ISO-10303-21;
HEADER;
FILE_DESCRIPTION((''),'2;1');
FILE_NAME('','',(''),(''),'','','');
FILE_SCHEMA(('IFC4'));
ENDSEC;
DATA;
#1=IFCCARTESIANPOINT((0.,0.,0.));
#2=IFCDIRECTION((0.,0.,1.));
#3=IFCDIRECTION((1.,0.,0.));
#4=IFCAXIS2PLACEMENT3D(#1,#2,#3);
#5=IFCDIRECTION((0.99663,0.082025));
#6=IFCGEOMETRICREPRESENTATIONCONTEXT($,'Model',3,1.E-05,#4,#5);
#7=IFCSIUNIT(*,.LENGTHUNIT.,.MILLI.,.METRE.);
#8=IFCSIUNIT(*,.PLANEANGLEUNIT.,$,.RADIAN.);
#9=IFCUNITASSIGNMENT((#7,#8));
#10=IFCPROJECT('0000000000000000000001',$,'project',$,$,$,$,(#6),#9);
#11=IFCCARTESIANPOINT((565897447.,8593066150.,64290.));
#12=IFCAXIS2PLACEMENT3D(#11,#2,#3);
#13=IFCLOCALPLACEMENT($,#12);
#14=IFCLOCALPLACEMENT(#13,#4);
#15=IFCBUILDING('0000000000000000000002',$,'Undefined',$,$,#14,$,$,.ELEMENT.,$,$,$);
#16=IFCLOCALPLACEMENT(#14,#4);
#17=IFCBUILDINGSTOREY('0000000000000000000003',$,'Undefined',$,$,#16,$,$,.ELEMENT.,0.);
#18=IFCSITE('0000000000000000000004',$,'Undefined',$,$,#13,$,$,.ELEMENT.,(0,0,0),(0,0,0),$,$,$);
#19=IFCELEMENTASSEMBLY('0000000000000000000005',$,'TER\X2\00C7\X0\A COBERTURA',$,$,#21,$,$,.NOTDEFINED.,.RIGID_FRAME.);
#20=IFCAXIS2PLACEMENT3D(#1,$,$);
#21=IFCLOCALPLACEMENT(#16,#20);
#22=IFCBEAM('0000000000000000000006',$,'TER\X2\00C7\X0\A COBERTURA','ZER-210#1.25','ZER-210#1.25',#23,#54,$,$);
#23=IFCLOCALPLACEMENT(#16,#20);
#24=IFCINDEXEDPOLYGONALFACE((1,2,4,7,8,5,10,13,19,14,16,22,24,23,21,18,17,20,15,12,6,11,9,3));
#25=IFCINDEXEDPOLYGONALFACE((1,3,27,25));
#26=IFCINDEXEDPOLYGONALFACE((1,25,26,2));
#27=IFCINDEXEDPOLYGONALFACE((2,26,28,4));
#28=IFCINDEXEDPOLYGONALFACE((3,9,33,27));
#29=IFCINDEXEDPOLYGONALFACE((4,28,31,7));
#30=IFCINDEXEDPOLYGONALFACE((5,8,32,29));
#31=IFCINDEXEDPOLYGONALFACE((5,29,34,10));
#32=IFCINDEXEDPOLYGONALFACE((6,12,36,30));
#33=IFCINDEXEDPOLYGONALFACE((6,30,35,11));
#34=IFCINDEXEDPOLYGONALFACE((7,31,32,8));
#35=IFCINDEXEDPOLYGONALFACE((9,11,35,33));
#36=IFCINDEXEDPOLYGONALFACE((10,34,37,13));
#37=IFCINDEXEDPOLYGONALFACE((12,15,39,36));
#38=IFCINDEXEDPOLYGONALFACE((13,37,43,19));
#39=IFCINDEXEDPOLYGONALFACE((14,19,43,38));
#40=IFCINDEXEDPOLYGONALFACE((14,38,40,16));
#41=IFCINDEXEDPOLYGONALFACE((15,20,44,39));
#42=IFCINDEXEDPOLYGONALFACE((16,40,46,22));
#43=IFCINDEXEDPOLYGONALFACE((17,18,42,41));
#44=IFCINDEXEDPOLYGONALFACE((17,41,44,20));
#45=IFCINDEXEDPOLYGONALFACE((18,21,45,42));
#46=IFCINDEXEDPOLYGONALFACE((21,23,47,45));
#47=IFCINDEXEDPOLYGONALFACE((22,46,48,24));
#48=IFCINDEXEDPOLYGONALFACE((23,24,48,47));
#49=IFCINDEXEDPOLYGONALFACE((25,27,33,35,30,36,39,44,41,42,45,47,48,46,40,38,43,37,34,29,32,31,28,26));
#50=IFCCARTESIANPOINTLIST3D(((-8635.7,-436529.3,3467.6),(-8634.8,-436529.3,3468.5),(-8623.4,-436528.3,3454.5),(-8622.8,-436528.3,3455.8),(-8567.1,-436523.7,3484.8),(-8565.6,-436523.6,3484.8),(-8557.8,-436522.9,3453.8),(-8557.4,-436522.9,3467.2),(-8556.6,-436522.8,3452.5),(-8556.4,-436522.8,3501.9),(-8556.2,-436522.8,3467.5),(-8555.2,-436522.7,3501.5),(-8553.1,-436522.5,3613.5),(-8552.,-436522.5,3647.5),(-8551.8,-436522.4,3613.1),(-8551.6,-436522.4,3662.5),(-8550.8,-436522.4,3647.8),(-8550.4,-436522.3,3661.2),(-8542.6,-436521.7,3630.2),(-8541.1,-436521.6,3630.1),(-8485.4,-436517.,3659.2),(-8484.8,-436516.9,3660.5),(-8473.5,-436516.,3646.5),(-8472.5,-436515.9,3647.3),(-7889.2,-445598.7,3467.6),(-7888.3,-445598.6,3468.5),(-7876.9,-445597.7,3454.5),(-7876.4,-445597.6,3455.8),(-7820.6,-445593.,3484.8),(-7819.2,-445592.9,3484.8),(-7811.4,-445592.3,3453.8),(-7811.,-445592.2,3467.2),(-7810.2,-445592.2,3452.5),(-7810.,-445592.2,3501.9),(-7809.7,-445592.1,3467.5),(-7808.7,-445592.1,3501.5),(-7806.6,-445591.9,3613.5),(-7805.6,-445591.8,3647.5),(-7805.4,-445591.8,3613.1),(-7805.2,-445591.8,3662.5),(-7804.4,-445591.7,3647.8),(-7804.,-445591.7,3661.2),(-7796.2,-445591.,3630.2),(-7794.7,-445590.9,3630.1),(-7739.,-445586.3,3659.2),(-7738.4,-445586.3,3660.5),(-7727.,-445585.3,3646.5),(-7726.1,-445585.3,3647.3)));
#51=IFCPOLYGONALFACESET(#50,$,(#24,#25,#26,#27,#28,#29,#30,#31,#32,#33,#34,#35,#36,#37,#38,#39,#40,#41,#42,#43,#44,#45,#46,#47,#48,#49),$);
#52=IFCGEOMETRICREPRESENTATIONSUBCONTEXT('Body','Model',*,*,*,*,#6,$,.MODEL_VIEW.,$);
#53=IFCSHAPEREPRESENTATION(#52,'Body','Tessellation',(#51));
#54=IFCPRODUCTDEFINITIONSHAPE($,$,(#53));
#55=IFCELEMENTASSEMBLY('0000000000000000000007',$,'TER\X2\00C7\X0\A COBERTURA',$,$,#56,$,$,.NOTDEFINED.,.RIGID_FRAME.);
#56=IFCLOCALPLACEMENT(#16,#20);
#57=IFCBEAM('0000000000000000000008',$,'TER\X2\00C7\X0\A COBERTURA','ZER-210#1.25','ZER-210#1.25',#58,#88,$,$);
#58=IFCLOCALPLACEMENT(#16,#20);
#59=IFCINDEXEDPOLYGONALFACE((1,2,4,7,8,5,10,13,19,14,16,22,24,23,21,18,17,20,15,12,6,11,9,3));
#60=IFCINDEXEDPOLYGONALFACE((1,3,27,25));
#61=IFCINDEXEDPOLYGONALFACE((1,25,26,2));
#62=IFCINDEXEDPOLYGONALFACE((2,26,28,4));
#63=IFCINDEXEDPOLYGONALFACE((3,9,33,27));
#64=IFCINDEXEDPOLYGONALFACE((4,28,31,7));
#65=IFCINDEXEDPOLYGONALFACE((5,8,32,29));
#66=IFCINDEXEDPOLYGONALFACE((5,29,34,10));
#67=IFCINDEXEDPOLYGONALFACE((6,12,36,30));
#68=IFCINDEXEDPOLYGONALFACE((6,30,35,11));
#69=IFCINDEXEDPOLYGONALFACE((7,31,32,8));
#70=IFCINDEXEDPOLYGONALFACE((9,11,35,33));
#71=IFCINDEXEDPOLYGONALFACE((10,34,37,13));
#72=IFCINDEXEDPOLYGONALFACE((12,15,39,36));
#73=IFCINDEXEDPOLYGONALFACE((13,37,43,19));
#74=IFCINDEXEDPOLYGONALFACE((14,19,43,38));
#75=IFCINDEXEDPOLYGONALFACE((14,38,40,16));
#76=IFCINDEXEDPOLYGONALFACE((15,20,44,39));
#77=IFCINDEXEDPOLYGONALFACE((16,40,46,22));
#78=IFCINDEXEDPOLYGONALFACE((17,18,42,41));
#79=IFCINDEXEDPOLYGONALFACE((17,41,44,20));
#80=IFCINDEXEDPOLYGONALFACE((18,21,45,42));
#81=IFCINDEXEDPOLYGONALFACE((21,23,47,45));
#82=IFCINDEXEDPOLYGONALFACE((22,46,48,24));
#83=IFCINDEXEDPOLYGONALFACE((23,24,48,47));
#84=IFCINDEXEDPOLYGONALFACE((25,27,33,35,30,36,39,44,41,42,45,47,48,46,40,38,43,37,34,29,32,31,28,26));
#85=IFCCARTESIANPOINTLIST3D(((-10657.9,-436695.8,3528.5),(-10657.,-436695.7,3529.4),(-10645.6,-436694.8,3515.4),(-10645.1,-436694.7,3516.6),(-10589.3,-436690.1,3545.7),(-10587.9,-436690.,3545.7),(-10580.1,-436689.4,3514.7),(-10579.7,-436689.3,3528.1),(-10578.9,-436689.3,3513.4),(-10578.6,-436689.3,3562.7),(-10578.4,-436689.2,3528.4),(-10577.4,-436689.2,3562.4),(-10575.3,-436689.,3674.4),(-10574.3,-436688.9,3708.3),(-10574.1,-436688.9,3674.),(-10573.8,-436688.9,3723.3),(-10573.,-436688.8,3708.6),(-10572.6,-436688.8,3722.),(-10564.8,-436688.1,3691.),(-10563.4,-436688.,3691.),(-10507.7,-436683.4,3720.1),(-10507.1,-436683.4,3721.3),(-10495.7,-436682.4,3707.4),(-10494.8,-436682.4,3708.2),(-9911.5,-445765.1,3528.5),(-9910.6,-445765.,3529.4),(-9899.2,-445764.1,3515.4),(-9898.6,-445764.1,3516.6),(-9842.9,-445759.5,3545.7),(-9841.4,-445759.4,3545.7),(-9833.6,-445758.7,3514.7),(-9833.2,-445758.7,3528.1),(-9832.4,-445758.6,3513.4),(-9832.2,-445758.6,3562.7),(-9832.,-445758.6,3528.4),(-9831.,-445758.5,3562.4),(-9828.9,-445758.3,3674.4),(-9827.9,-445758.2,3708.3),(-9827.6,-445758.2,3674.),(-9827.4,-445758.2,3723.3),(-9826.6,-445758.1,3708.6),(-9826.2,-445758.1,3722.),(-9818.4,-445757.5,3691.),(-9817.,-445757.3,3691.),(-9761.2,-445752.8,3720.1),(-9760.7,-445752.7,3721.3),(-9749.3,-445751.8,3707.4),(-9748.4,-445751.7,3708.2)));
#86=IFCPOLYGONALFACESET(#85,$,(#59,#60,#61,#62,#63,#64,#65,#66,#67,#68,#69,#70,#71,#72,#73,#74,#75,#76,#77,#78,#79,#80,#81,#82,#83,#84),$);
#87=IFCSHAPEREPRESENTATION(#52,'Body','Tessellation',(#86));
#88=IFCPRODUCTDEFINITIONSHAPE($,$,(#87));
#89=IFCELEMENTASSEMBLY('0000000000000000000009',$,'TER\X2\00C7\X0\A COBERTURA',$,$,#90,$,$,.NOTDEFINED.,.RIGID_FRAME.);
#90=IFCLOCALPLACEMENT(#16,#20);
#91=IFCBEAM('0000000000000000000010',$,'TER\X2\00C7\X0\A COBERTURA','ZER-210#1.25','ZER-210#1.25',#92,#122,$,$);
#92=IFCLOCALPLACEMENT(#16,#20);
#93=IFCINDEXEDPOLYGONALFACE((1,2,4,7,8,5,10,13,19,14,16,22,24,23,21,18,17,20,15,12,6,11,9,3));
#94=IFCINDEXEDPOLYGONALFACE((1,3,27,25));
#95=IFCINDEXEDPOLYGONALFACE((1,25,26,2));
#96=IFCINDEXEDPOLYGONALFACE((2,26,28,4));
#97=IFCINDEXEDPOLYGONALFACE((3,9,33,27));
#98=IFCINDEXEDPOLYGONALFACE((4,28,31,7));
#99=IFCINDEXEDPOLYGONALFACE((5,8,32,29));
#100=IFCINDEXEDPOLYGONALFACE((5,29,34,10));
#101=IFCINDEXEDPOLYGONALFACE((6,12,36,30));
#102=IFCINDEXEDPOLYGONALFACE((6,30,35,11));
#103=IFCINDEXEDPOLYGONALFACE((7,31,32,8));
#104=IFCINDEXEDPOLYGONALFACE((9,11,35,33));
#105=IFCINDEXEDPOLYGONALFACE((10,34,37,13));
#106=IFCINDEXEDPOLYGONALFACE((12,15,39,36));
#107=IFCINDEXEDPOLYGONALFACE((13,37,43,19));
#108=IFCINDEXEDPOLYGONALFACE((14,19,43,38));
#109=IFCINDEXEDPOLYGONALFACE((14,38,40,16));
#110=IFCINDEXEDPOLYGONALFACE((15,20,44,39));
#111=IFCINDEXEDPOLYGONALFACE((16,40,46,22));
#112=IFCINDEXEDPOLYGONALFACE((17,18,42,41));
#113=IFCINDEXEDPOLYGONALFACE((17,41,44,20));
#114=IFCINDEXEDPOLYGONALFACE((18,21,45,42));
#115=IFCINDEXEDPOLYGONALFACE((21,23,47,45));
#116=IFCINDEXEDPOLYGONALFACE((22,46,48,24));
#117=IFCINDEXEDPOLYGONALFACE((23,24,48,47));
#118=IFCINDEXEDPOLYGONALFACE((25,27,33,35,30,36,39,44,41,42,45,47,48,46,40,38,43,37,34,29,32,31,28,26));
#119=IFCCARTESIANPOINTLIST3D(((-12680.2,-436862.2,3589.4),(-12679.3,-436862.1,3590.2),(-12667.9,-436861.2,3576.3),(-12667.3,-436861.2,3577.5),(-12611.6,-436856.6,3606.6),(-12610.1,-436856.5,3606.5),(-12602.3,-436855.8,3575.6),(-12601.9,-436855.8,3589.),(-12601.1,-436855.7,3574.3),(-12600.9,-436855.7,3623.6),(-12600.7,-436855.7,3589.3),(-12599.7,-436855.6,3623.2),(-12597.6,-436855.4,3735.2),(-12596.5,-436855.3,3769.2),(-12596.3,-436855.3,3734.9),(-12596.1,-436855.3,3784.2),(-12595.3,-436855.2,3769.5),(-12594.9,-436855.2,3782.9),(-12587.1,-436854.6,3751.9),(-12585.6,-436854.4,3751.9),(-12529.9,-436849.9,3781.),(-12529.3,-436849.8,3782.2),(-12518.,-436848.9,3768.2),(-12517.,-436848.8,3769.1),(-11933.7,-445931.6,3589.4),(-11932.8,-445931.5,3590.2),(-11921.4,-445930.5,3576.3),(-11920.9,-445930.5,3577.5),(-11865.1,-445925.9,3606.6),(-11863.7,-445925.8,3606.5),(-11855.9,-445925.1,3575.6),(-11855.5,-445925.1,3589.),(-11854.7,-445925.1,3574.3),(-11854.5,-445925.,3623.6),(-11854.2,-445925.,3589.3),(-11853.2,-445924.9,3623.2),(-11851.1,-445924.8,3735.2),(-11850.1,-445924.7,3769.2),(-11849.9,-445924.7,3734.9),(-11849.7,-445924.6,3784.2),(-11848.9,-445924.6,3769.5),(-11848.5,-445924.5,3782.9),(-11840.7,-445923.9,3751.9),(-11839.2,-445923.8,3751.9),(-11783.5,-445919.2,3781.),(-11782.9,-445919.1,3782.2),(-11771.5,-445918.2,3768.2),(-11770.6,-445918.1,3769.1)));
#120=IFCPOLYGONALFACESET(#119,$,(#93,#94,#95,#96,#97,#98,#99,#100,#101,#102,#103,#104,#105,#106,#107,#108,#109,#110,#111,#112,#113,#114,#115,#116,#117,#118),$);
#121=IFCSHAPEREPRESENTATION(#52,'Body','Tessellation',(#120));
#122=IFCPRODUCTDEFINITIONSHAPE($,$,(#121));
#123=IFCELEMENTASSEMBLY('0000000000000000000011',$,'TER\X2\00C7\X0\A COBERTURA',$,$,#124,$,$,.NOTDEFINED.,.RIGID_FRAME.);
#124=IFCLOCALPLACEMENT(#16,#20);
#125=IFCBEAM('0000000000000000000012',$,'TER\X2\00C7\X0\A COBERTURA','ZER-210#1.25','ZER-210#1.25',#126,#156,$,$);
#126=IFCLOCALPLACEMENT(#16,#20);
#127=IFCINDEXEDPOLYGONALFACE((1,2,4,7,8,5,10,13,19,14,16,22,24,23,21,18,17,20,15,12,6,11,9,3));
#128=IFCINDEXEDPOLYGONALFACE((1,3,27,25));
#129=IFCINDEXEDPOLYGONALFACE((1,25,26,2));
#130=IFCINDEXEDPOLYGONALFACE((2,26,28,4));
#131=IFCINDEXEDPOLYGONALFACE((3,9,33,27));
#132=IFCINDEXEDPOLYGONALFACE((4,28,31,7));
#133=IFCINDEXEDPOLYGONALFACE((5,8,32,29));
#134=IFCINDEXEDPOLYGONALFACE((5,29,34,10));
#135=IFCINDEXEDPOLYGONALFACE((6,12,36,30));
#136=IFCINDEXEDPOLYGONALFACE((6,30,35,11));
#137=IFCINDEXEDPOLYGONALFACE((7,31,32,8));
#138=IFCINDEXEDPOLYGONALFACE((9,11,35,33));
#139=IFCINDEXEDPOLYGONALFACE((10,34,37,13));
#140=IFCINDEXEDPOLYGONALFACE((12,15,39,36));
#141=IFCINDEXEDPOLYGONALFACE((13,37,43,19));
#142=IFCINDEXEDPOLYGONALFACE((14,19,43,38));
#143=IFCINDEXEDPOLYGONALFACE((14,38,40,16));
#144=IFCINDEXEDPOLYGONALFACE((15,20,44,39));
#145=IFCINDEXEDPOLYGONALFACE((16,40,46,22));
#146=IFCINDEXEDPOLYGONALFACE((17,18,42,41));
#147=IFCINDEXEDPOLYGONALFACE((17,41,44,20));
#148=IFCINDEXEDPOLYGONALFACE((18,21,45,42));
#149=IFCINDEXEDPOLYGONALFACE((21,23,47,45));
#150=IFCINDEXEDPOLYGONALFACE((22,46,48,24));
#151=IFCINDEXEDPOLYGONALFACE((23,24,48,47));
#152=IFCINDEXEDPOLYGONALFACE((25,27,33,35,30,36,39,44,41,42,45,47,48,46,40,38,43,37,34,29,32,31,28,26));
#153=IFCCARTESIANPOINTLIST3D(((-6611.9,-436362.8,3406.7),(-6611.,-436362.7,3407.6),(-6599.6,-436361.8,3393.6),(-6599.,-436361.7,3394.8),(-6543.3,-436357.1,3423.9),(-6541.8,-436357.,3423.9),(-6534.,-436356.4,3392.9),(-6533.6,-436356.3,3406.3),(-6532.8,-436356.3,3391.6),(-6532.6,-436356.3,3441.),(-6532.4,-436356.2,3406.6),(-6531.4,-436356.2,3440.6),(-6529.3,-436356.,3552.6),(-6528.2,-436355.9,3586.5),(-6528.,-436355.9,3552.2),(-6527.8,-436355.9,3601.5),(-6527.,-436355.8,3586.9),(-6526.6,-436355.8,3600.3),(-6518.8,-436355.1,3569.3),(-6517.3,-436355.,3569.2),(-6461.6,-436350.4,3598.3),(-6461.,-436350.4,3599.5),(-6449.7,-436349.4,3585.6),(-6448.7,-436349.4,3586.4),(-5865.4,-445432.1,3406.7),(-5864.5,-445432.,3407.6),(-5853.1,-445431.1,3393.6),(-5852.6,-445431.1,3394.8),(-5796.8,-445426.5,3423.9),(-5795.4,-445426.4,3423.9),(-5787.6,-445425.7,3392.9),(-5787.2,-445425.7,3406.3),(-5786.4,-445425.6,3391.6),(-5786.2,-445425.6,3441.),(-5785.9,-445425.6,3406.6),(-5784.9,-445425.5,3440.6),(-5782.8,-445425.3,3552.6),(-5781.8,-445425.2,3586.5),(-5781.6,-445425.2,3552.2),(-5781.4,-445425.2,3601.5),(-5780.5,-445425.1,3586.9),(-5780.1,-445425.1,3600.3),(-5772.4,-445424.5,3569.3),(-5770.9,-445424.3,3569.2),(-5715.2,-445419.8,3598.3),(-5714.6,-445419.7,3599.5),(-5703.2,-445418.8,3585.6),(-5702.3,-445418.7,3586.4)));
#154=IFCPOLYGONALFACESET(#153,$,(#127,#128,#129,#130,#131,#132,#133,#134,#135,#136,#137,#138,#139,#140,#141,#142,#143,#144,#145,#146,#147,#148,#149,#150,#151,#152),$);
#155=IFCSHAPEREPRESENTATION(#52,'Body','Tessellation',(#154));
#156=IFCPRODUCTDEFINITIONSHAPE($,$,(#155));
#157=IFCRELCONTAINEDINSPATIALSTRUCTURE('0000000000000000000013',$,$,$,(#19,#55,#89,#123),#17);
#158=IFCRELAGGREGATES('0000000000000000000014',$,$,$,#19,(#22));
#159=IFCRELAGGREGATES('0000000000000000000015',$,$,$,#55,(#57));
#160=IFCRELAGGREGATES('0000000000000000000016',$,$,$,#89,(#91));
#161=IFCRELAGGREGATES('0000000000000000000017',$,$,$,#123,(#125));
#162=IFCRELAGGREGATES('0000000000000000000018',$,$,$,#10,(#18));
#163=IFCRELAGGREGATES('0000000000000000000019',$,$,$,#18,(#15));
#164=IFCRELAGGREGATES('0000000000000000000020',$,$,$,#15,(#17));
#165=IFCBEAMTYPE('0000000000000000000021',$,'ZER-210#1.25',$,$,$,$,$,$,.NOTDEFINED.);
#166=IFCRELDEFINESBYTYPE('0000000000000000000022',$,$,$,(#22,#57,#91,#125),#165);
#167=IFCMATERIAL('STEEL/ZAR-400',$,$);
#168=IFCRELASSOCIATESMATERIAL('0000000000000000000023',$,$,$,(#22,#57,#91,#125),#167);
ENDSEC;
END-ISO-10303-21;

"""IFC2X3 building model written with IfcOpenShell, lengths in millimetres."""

from ifc_helpers import new_model, si_unit, direction, frame, origin_with_axes, place, context, subcontext, project, spatial, polyline, outline, extrude, material, type_object, element, aggregate, save


model = new_model("IFC2X3")

# Units and contexts
model_context = context("Model", 3, precision=1e-05, world=origin_with_axes(), true_north=direction((0.99663, 0.082025)))
body_context = subcontext(model_context, "Body", "Model", "MODEL_VIEW")
ifc_project = project(units=[si_unit("LENGTHUNIT", "METRE", prefix="MILLI"), si_unit("PLANEANGLEUNIT", "RADIAN")], contexts=[model_context])

# Site, building, storey
site_placement = place(None, frame((565897447.0, 8593066150.0, 64290.0), z_axis=(0.0, 0.0, 1.0), x_axis=(1.0, 0.0, 0.0)))
site = spatial("IfcSite", under=ifc_project, at=site_placement, Name="Undefined", CompositionType="ELEMENT", RefLatitude=(0, 0, 0), RefLongitude=(0, 0, 0))
building_placement = place(site_placement, origin_with_axes())
building = spatial("IfcBuilding", under=site, at=building_placement, Name="Undefined", CompositionType="ELEMENT")
storey_placement = place(building_placement, origin_with_axes())
storey = spatial("IfcBuildingStorey", under=building, at=storey_placement, Name="Undefined", CompositionType="ELEMENT", Elevation=0.0)

# Element assemblies, beams
assembly_1_placement = place(storey_placement, origin_with_axes())
assembly_1 = element("IfcElementAssembly", 1, at=assembly_1_placement, inside=storey, Name="TERÇA COBERTURA", AssemblyPlace="NOTDEFINED", PredefinedType="RIGID_FRAME")
ifc_material_1 = material(Name="STEEL/ZAR-400")
beam_type_1 = type_object("IfcBeamType", Name="ZER-210#1.25", PredefinedType="NOTDEFINED")
beam_1_placement = place(assembly_1_placement, frame((-8554.1, -436522.6, 3557.5), z_axis=(0.029885, 0.00246, 0.99955), x_axis=(0.082025, -0.99663, 0.0)))
beam_1 = element("IfcBeam", 2, at=beam_1_placement, type_object=beam_type_1, material=ifc_material_1, Name="TERÇA COBERTURA", Description="ZER-210#1.25", ObjectType="ZER-210#1.25", context=body_context, shape_type="SweptSolid", body=[
    extrude(outline(polyline([(-65.9, 103.7), (-78.2, 91.4), (-79.1, 92.3), (-66.4, 105.0), (0.6, 105.0), (0.6, 90.0), (-9.4, 73.0), (0.6, 56.0), (0.6, -55.7), (10.8, -73.0), (0.6, -90.3), (0.6, -103.8), (65.9, -103.7), (78.2, -91.4), (79.1, -92.3), (66.4, -105.0), (-0.6, -105.0), (-0.6, -90.0), (9.4, -73.0), (-0.6, -56.0), (-0.6, 55.7), (-10.8, 73.0), (-0.6, 90.3), (-0.6, 103.8), (-65.9, 103.7)])), frame((9100.0, 0.0, 0.0), z_axis=(-1.0, 0.0, 0.0), x_axis=(0.0, -1.0, 0.0)), (0.0, 0.0, 1.0), 9100.0),
])
aggregate(assembly_1, [beam_1])
assembly_2_placement = place(storey_placement, origin_with_axes())
assembly_2 = element("IfcElementAssembly", 3, at=assembly_2_placement, inside=storey, Name="TERÇA COBERTURA", AssemblyPlace="NOTDEFINED", PredefinedType="RIGID_FRAME")
beam_2_placement = place(assembly_2_placement, frame((-10576.4, -436689.1, 3618.4), z_axis=(0.029885, 0.00246, 0.99955), x_axis=(0.082025, -0.99663, 0.0)))
beam_2 = element("IfcBeam", 4, at=beam_2_placement, type_object=beam_type_1, material=ifc_material_1, Name="TERÇA COBERTURA", Description="ZER-210#1.25", ObjectType="ZER-210#1.25", context=body_context, shape_type="SweptSolid", body=[
    extrude(outline(polyline([(-65.9, 103.7), (-78.2, 91.4), (-79.1, 92.3), (-66.4, 105.0), (0.6, 105.0), (0.6, 90.0), (-9.4, 73.0), (0.6, 56.0), (0.6, -55.7), (10.8, -73.0), (0.6, -90.3), (0.6, -103.8), (65.9, -103.7), (78.2, -91.4), (79.1, -92.3), (66.4, -105.0), (-0.6, -105.0), (-0.6, -90.0), (9.4, -73.0), (-0.6, -56.0), (-0.6, 55.7), (-10.8, 73.0), (-0.6, 90.3), (-0.6, 103.8), (-65.9, 103.7)])), frame((9100.0, 0.0, 0.0), z_axis=(-1.0, 0.0, 0.0), x_axis=(0.0, -1.0, 0.0)), (0.0, 0.0, 1.0), 9100.0),
])
aggregate(assembly_2, [beam_2])
assembly_3_placement = place(storey_placement, origin_with_axes())
assembly_3 = element("IfcElementAssembly", 5, at=assembly_3_placement, inside=storey, Name="TERÇA COBERTURA", AssemblyPlace="NOTDEFINED", PredefinedType="RIGID_FRAME")
beam_3_placement = place(assembly_3_placement, frame((-12598.6, -436855.5, 3679.2), z_axis=(0.029885, 0.00246, 0.99955), x_axis=(0.082025, -0.99663, 0.0)))
beam_3 = element("IfcBeam", 6, at=beam_3_placement, type_object=beam_type_1, material=ifc_material_1, Name="TERÇA COBERTURA", Description="ZER-210#1.25", ObjectType="ZER-210#1.25", context=body_context, shape_type="SweptSolid", body=[
    extrude(outline(polyline([(-65.9, 103.7), (-78.2, 91.4), (-79.1, 92.3), (-66.4, 105.0), (0.6, 105.0), (0.6, 90.0), (-9.4, 73.0), (0.6, 56.0), (0.6, -55.7), (10.8, -73.0), (0.6, -90.3), (0.6, -103.8), (65.9, -103.7), (78.2, -91.4), (79.1, -92.3), (66.4, -105.0), (-0.6, -105.0), (-0.6, -90.0), (9.4, -73.0), (-0.6, -56.0), (-0.6, 55.7), (-10.8, 73.0), (-0.6, 90.3), (-0.6, 103.8), (-65.9, 103.7)])), frame((9100.0, 0.0, 0.0), z_axis=(-1.0, 0.0, 0.0), x_axis=(0.0, -1.0, 0.0)), (0.0, 0.0, 1.0), 9100.0),
])
aggregate(assembly_3, [beam_3])
assembly_4_placement = place(storey_placement, origin_with_axes())
assembly_4 = element("IfcElementAssembly", 7, at=assembly_4_placement, inside=storey, Name="TERÇA COBERTURA", AssemblyPlace="NOTDEFINED", PredefinedType="RIGID_FRAME")
beam_4_placement = place(assembly_4_placement, frame((-6530.3, -436356.1, 3496.6), z_axis=(0.029885, 0.00246, 0.99955), x_axis=(0.082025, -0.99663, 0.0)))
beam_4 = element("IfcBeam", 8, at=beam_4_placement, type_object=beam_type_1, material=ifc_material_1, Name="TERÇA COBERTURA", Description="ZER-210#1.25", ObjectType="ZER-210#1.25", context=body_context, shape_type="SweptSolid", body=[
    extrude(outline(polyline([(-65.9, 103.7), (-78.2, 91.4), (-79.1, 92.3), (-66.4, 105.0), (0.6, 105.0), (0.6, 90.0), (-9.4, 73.0), (0.6, 56.0), (0.6, -55.7), (10.8, -73.0), (0.6, -90.3), (0.6, -103.8), (65.9, -103.7), (78.2, -91.4), (79.1, -92.3), (66.4, -105.0), (-0.6, -105.0), (-0.6, -90.0), (9.4, -73.0), (-0.6, -56.0), (-0.6, 55.7), (-10.8, 73.0), (-0.6, 90.3), (-0.6, 103.8), (-65.9, 103.7)])), frame((9100.0, 0.0, 0.0), z_axis=(-1.0, 0.0, 0.0), x_axis=(0.0, -1.0, 0.0)), (0.0, 0.0, 1.0), 9100.0),
])
aggregate(assembly_4, [beam_4])

save(model, "model.ifc")
